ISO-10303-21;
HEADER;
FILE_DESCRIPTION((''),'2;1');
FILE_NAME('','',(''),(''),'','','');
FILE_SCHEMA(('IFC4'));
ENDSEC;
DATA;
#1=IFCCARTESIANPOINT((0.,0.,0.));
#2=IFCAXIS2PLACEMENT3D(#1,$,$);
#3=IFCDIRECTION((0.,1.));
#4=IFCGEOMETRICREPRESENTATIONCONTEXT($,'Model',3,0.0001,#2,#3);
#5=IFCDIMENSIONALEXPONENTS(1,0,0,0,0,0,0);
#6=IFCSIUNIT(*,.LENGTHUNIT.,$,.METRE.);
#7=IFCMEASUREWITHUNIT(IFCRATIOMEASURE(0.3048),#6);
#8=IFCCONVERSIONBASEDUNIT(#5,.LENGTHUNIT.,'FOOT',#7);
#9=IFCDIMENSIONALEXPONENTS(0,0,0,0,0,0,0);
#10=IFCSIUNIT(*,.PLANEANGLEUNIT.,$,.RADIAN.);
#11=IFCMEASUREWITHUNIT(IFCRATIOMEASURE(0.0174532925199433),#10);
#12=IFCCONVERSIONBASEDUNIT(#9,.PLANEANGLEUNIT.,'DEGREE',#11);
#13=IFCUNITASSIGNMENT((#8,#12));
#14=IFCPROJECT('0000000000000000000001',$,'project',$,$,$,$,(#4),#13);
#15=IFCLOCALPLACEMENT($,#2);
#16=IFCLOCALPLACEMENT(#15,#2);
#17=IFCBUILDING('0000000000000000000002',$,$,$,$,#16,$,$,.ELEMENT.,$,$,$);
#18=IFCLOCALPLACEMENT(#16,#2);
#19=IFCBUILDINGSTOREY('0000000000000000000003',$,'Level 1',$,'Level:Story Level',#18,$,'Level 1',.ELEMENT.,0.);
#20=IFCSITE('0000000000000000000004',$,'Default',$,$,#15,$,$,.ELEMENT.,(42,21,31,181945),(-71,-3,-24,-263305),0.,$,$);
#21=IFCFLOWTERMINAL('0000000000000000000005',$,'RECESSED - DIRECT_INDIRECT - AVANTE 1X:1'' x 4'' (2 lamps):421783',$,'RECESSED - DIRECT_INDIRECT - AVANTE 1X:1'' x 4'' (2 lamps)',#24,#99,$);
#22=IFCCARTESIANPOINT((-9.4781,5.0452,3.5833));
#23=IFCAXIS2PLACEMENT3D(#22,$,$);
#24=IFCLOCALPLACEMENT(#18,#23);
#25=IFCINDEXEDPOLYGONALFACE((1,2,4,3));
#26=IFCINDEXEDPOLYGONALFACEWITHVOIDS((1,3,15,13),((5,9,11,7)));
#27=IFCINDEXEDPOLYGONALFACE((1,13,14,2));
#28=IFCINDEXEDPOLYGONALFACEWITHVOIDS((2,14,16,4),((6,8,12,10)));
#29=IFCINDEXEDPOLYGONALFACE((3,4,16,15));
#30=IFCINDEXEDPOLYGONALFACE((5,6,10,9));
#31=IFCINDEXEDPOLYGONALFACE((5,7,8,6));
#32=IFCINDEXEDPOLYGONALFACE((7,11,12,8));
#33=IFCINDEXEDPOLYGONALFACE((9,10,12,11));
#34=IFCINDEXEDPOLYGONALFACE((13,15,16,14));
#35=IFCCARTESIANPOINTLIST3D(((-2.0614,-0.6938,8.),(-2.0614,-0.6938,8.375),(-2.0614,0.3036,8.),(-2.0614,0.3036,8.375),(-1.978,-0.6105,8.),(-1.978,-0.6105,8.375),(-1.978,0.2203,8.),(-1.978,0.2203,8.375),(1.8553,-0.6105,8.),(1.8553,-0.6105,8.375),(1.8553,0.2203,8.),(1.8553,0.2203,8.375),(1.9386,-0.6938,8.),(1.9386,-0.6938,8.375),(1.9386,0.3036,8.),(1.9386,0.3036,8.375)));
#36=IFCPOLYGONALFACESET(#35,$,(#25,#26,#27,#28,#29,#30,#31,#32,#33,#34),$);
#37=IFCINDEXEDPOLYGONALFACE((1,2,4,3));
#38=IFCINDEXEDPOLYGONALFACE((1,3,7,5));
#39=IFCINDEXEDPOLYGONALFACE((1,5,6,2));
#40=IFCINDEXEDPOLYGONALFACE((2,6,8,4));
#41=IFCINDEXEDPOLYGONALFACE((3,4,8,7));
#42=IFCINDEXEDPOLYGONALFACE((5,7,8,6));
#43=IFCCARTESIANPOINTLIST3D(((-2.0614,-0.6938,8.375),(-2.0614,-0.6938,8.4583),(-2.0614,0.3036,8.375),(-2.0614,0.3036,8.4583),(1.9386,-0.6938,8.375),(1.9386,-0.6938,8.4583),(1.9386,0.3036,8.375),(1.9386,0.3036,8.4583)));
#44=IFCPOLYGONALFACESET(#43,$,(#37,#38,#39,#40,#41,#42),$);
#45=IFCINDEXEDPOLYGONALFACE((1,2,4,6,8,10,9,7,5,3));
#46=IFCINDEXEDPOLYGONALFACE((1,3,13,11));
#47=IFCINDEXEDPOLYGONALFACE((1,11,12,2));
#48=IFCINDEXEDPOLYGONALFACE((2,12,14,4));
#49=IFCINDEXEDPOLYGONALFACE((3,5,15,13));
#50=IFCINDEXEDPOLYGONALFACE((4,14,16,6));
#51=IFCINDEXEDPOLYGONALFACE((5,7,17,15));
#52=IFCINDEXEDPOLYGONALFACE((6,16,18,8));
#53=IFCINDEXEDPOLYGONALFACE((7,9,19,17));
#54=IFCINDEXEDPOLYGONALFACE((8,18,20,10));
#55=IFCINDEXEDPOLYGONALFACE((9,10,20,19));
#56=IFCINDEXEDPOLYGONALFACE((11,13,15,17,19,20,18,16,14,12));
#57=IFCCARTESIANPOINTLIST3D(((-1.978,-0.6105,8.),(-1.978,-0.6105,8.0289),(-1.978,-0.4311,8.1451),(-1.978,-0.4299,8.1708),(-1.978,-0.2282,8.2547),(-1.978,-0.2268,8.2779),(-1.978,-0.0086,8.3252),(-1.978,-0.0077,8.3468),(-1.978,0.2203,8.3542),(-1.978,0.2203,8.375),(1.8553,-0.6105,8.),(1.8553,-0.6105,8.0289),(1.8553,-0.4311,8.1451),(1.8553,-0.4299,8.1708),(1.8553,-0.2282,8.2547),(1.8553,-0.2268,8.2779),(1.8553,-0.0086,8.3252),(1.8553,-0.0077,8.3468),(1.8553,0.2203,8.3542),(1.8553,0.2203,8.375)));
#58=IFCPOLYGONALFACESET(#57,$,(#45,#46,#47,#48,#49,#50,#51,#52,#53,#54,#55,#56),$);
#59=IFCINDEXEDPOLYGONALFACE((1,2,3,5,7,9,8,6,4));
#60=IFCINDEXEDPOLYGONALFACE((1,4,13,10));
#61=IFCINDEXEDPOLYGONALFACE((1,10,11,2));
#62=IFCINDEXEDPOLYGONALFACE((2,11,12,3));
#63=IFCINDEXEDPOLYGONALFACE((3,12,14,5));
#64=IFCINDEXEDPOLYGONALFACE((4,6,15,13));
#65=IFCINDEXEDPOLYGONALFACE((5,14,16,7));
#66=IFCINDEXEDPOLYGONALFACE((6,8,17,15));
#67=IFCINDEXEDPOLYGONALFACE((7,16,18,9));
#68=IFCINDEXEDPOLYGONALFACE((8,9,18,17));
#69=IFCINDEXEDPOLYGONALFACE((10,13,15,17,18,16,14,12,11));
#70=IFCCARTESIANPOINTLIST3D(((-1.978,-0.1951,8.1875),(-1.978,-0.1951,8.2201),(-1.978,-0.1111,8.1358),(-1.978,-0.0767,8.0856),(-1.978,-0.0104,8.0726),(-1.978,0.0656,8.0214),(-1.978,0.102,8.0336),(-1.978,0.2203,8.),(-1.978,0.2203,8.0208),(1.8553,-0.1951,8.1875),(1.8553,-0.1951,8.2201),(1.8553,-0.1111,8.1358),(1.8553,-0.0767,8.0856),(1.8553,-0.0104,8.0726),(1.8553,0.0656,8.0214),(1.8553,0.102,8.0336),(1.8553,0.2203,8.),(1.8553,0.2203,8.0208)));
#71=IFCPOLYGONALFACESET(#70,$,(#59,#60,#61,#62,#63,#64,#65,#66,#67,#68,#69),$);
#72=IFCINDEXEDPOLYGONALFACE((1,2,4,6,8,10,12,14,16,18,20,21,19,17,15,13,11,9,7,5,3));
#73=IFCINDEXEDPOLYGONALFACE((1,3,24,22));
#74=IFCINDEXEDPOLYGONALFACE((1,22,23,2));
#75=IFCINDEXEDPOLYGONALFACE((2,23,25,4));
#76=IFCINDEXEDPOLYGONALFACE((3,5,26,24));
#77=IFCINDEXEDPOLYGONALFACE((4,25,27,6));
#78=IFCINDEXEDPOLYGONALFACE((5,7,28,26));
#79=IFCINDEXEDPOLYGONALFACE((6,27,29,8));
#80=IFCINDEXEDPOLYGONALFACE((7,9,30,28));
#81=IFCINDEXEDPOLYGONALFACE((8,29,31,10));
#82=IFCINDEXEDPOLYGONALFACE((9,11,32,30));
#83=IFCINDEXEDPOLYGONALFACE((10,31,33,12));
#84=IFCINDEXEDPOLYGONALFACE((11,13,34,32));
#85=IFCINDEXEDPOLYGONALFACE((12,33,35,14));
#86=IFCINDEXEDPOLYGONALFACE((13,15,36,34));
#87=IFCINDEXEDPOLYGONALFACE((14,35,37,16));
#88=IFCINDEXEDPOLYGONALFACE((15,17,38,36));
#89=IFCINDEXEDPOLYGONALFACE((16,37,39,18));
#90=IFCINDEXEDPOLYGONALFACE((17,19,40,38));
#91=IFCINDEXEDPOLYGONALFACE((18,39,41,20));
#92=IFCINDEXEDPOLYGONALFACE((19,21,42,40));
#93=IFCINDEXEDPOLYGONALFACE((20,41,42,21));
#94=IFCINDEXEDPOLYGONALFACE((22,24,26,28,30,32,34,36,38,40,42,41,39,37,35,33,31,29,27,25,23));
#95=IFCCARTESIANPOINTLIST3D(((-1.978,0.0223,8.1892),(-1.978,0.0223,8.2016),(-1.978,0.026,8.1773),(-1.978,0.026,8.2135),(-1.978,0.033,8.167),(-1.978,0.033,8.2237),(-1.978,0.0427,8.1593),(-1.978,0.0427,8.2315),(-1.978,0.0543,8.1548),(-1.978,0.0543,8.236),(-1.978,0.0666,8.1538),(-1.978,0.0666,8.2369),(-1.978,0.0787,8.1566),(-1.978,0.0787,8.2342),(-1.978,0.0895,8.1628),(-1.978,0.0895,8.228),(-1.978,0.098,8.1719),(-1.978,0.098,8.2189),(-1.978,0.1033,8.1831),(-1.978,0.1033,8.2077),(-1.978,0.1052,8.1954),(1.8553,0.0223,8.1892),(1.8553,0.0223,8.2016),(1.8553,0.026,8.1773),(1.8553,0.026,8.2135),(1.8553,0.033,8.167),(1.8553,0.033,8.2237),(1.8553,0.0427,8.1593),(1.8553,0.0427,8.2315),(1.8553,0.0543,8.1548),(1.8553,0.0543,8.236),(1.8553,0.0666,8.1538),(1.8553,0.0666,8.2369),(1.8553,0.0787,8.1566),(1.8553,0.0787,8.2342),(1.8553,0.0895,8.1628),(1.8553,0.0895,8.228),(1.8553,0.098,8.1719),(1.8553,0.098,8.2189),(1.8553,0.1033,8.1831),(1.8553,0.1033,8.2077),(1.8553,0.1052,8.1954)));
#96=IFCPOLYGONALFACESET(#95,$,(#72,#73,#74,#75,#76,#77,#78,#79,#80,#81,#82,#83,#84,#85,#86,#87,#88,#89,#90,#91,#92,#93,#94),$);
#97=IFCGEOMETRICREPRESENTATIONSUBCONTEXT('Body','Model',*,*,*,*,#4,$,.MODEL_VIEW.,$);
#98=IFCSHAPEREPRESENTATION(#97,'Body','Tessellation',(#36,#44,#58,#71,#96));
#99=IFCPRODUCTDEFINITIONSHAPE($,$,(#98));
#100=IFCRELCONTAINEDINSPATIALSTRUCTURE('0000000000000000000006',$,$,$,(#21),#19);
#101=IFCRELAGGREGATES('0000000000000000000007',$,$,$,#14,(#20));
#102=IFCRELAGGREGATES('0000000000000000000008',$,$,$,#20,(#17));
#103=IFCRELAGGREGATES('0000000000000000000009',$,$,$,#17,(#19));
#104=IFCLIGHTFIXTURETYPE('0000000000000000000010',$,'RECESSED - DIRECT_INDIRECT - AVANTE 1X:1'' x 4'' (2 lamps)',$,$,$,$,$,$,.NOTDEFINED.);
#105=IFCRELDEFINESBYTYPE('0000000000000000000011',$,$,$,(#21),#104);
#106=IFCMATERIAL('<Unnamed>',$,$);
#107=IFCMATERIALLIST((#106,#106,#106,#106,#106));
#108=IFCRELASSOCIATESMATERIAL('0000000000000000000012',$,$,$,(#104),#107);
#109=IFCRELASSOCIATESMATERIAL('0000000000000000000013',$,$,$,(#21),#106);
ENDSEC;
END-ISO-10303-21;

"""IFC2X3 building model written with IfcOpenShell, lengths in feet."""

from ifc_helpers import new_model, entity, si_unit, converted_unit, direction, frame, frame_2d, origin, origin_2d_with_axis, place, context, subcontext, project, spatial, polyline, circle_curve, parameter, trimmed, segment, composite_curve, rectangle, circle, outline, extrude, source, transform, mapped, material, material_list, type_object, type_shapes, element, save


model = new_model("IFC2X3")

# Units and contexts
model_context = context("Model", 3, precision=0.0001, world=origin(), true_north=direction((0.0, 1.0)))
body_context = subcontext(model_context, "Body", "Model", "MODEL_VIEW")
ifc_project = project(units=[converted_unit("LENGTHUNIT", "FOOT", entity("IfcRatioMeasure", 0.3048), si_unit("LENGTHUNIT", "METRE"), dimensions=[1, 0, 0, 0, 0, 0, 0]), converted_unit("PLANEANGLEUNIT", "DEGREE", entity("IfcRatioMeasure", 0.0174532925199433), si_unit("PLANEANGLEUNIT", "RADIAN"), dimensions=[0, 0, 0, 0, 0, 0, 0])], contexts=[model_context])

# Site, building, storey
site_placement = place(None, origin())
site = spatial("IfcSite", under=ifc_project, at=site_placement, Name="Default", CompositionType="ELEMENT", RefLatitude=(42, 21, 31, 181945), RefLongitude=(-71, -3, -24, -263305), RefElevation=0.0)
building_placement = place(site_placement, origin())
building = spatial("IfcBuilding", under=site, at=building_placement, CompositionType="ELEMENT")
storey_placement = place(building_placement, origin())
storey = spatial("IfcBuildingStorey", under=building, at=storey_placement, Name="Level 1", ObjectType="Level:Story Level", LongName="Level 1", CompositionType="ELEMENT", Elevation=0.0)

# Flow terminal
ifc_material_1 = material(Name="<Unnamed>")
ifc_material_list_1 = material_list([ifc_material_1, ifc_material_1, ifc_material_1, ifc_material_1, ifc_material_1])
light_fixture_type = type_object("IfcLightFixtureType", Name="RECESSED - DIRECT_INDIRECT - AVANTE 1X:1' x 4' (2 lamps)", PredefinedType="NOTDEFINED", material=ifc_material_list_1)
shared_shape_1 = source(origin(), body_context, "Body", "SweptSolid", [
    extrude(outline(polyline([(-2.0, -0.4987), (2.0, -0.4987), (2.0, 0.4987), (-2.0, 0.4987), (-2.0, -0.4987)]), holes=[polyline([(-1.9167, -0.4154), (-1.9167, 0.4154), (1.9167, 0.4154), (1.9167, -0.4154), (-1.9167, -0.4154)])]), frame((-0.0614, -0.1951, 8.0), z_axis=(0.0, 0.0, 1.0), x_axis=(-1.0, 0.0, 0.0)), (0.0, 0.0, 1.0), 0.375),
    extrude(rectangle(XDim=4.0, YDim=0.9974, at=origin_2d_with_axis()), frame((-0.0614, -0.1951, 8.375), z_axis=(0.0, 0.0, 1.0), x_axis=(-1.0, 0.0, 0.0)), (0.0, 0.0, 1.0), 0.0833),
    extrude(outline(composite_curve([segment(trimmed(circle_curve(frame_2d((-1.0846, 0.4571), x_axis=(-1.0, 0.0)), 1.25), [parameter(135.734122)], [parameter(178.085644)], True, "PARAMETER"), False, "CONTINUOUS"), segment(polyline([(-0.1895, -0.4154), (-0.1606, -0.4154)]), True, "CONTINUOUS"), segment(trimmed(circle_curve(frame_2d((-1.0846, 0.4571), x_axis=(-1.0, 0.0)), 1.2708), [parameter(136.642648)], [parameter(178.117038)], True, "PARAMETER"), True, "CONTINUOUS"), segment(polyline([(0.1855, 0.4154), (0.1647, 0.4154)]), True, "CONTINUOUS")], self_intersect=False)), frame((-1.978, -0.1951, 8.1895), z_axis=(-1.0, 0.0, 0.0), x_axis=(0.0, 0.0, 1.0)), (0.0, 0.0, -1.0), 3.8333),
    extrude(outline(composite_curve([segment(polyline([(0.0863, -0.2077), (0.1071, -0.2077)]), True, "CONTINUOUS"), segment(trimmed(circle_curve(frame_2d((-0.4397, -0.2045), x_axis=(1.0, 0.0)), 0.5468), [parameter(359.668292)], [parameter(48.921556)], True, "PARAMETER"), True, "CONTINUOUS"), segment(polyline([(-0.0804, 0.2077), (-0.113, 0.2077)]), True, "CONTINUOUS"), segment(trimmed(circle_curve(frame_2d((-0.4397, -0.2045), x_axis=(1.0, 0.0)), 0.526), [parameter(359.655153)], [parameter(51.59762)], True, "PARAMETER"), False, "CONTINUOUS")], self_intersect=False)), frame((-1.978, 0.0126, 8.1071), z_axis=(-1.0, 0.0, 0.0), x_axis=(0.0, 0.0, -1.0)), (0.0, 0.0, -1.0), 3.8333),
    extrude(circle(Radius=0.0417, at=origin_2d_with_axis()), frame((-1.978, 0.0635, 8.1954), z_axis=(1.0, 0.0, 0.0), x_axis=(0.0, 1.0, 0.0)), (0.0, 0.0, 1.0), 3.8333),
])
type_shapes(light_fixture_type, [shared_shape_1])
for number, where, name in (
    (1, (-9.4781, 5.0452, 3.5833), "RECESSED - DIRECT_INDIRECT - AVANTE 1X:1' x 4' (2 lamps):421783"),
):
    element("IfcFlowTerminal", number, at=place(storey_placement, frame(where)), inside=storey, type_object=light_fixture_type, material=ifc_material_1, Name=name, ObjectType="RECESSED - DIRECT_INDIRECT - AVANTE 1X:1' x 4' (2 lamps)", context=body_context, shape_type="MappedRepresentation", body=[
        mapped(shared_shape_1, transform((0.0, 0.0, 0.0), scale=1.0)),
    ])

save(model, "model.ifc")
